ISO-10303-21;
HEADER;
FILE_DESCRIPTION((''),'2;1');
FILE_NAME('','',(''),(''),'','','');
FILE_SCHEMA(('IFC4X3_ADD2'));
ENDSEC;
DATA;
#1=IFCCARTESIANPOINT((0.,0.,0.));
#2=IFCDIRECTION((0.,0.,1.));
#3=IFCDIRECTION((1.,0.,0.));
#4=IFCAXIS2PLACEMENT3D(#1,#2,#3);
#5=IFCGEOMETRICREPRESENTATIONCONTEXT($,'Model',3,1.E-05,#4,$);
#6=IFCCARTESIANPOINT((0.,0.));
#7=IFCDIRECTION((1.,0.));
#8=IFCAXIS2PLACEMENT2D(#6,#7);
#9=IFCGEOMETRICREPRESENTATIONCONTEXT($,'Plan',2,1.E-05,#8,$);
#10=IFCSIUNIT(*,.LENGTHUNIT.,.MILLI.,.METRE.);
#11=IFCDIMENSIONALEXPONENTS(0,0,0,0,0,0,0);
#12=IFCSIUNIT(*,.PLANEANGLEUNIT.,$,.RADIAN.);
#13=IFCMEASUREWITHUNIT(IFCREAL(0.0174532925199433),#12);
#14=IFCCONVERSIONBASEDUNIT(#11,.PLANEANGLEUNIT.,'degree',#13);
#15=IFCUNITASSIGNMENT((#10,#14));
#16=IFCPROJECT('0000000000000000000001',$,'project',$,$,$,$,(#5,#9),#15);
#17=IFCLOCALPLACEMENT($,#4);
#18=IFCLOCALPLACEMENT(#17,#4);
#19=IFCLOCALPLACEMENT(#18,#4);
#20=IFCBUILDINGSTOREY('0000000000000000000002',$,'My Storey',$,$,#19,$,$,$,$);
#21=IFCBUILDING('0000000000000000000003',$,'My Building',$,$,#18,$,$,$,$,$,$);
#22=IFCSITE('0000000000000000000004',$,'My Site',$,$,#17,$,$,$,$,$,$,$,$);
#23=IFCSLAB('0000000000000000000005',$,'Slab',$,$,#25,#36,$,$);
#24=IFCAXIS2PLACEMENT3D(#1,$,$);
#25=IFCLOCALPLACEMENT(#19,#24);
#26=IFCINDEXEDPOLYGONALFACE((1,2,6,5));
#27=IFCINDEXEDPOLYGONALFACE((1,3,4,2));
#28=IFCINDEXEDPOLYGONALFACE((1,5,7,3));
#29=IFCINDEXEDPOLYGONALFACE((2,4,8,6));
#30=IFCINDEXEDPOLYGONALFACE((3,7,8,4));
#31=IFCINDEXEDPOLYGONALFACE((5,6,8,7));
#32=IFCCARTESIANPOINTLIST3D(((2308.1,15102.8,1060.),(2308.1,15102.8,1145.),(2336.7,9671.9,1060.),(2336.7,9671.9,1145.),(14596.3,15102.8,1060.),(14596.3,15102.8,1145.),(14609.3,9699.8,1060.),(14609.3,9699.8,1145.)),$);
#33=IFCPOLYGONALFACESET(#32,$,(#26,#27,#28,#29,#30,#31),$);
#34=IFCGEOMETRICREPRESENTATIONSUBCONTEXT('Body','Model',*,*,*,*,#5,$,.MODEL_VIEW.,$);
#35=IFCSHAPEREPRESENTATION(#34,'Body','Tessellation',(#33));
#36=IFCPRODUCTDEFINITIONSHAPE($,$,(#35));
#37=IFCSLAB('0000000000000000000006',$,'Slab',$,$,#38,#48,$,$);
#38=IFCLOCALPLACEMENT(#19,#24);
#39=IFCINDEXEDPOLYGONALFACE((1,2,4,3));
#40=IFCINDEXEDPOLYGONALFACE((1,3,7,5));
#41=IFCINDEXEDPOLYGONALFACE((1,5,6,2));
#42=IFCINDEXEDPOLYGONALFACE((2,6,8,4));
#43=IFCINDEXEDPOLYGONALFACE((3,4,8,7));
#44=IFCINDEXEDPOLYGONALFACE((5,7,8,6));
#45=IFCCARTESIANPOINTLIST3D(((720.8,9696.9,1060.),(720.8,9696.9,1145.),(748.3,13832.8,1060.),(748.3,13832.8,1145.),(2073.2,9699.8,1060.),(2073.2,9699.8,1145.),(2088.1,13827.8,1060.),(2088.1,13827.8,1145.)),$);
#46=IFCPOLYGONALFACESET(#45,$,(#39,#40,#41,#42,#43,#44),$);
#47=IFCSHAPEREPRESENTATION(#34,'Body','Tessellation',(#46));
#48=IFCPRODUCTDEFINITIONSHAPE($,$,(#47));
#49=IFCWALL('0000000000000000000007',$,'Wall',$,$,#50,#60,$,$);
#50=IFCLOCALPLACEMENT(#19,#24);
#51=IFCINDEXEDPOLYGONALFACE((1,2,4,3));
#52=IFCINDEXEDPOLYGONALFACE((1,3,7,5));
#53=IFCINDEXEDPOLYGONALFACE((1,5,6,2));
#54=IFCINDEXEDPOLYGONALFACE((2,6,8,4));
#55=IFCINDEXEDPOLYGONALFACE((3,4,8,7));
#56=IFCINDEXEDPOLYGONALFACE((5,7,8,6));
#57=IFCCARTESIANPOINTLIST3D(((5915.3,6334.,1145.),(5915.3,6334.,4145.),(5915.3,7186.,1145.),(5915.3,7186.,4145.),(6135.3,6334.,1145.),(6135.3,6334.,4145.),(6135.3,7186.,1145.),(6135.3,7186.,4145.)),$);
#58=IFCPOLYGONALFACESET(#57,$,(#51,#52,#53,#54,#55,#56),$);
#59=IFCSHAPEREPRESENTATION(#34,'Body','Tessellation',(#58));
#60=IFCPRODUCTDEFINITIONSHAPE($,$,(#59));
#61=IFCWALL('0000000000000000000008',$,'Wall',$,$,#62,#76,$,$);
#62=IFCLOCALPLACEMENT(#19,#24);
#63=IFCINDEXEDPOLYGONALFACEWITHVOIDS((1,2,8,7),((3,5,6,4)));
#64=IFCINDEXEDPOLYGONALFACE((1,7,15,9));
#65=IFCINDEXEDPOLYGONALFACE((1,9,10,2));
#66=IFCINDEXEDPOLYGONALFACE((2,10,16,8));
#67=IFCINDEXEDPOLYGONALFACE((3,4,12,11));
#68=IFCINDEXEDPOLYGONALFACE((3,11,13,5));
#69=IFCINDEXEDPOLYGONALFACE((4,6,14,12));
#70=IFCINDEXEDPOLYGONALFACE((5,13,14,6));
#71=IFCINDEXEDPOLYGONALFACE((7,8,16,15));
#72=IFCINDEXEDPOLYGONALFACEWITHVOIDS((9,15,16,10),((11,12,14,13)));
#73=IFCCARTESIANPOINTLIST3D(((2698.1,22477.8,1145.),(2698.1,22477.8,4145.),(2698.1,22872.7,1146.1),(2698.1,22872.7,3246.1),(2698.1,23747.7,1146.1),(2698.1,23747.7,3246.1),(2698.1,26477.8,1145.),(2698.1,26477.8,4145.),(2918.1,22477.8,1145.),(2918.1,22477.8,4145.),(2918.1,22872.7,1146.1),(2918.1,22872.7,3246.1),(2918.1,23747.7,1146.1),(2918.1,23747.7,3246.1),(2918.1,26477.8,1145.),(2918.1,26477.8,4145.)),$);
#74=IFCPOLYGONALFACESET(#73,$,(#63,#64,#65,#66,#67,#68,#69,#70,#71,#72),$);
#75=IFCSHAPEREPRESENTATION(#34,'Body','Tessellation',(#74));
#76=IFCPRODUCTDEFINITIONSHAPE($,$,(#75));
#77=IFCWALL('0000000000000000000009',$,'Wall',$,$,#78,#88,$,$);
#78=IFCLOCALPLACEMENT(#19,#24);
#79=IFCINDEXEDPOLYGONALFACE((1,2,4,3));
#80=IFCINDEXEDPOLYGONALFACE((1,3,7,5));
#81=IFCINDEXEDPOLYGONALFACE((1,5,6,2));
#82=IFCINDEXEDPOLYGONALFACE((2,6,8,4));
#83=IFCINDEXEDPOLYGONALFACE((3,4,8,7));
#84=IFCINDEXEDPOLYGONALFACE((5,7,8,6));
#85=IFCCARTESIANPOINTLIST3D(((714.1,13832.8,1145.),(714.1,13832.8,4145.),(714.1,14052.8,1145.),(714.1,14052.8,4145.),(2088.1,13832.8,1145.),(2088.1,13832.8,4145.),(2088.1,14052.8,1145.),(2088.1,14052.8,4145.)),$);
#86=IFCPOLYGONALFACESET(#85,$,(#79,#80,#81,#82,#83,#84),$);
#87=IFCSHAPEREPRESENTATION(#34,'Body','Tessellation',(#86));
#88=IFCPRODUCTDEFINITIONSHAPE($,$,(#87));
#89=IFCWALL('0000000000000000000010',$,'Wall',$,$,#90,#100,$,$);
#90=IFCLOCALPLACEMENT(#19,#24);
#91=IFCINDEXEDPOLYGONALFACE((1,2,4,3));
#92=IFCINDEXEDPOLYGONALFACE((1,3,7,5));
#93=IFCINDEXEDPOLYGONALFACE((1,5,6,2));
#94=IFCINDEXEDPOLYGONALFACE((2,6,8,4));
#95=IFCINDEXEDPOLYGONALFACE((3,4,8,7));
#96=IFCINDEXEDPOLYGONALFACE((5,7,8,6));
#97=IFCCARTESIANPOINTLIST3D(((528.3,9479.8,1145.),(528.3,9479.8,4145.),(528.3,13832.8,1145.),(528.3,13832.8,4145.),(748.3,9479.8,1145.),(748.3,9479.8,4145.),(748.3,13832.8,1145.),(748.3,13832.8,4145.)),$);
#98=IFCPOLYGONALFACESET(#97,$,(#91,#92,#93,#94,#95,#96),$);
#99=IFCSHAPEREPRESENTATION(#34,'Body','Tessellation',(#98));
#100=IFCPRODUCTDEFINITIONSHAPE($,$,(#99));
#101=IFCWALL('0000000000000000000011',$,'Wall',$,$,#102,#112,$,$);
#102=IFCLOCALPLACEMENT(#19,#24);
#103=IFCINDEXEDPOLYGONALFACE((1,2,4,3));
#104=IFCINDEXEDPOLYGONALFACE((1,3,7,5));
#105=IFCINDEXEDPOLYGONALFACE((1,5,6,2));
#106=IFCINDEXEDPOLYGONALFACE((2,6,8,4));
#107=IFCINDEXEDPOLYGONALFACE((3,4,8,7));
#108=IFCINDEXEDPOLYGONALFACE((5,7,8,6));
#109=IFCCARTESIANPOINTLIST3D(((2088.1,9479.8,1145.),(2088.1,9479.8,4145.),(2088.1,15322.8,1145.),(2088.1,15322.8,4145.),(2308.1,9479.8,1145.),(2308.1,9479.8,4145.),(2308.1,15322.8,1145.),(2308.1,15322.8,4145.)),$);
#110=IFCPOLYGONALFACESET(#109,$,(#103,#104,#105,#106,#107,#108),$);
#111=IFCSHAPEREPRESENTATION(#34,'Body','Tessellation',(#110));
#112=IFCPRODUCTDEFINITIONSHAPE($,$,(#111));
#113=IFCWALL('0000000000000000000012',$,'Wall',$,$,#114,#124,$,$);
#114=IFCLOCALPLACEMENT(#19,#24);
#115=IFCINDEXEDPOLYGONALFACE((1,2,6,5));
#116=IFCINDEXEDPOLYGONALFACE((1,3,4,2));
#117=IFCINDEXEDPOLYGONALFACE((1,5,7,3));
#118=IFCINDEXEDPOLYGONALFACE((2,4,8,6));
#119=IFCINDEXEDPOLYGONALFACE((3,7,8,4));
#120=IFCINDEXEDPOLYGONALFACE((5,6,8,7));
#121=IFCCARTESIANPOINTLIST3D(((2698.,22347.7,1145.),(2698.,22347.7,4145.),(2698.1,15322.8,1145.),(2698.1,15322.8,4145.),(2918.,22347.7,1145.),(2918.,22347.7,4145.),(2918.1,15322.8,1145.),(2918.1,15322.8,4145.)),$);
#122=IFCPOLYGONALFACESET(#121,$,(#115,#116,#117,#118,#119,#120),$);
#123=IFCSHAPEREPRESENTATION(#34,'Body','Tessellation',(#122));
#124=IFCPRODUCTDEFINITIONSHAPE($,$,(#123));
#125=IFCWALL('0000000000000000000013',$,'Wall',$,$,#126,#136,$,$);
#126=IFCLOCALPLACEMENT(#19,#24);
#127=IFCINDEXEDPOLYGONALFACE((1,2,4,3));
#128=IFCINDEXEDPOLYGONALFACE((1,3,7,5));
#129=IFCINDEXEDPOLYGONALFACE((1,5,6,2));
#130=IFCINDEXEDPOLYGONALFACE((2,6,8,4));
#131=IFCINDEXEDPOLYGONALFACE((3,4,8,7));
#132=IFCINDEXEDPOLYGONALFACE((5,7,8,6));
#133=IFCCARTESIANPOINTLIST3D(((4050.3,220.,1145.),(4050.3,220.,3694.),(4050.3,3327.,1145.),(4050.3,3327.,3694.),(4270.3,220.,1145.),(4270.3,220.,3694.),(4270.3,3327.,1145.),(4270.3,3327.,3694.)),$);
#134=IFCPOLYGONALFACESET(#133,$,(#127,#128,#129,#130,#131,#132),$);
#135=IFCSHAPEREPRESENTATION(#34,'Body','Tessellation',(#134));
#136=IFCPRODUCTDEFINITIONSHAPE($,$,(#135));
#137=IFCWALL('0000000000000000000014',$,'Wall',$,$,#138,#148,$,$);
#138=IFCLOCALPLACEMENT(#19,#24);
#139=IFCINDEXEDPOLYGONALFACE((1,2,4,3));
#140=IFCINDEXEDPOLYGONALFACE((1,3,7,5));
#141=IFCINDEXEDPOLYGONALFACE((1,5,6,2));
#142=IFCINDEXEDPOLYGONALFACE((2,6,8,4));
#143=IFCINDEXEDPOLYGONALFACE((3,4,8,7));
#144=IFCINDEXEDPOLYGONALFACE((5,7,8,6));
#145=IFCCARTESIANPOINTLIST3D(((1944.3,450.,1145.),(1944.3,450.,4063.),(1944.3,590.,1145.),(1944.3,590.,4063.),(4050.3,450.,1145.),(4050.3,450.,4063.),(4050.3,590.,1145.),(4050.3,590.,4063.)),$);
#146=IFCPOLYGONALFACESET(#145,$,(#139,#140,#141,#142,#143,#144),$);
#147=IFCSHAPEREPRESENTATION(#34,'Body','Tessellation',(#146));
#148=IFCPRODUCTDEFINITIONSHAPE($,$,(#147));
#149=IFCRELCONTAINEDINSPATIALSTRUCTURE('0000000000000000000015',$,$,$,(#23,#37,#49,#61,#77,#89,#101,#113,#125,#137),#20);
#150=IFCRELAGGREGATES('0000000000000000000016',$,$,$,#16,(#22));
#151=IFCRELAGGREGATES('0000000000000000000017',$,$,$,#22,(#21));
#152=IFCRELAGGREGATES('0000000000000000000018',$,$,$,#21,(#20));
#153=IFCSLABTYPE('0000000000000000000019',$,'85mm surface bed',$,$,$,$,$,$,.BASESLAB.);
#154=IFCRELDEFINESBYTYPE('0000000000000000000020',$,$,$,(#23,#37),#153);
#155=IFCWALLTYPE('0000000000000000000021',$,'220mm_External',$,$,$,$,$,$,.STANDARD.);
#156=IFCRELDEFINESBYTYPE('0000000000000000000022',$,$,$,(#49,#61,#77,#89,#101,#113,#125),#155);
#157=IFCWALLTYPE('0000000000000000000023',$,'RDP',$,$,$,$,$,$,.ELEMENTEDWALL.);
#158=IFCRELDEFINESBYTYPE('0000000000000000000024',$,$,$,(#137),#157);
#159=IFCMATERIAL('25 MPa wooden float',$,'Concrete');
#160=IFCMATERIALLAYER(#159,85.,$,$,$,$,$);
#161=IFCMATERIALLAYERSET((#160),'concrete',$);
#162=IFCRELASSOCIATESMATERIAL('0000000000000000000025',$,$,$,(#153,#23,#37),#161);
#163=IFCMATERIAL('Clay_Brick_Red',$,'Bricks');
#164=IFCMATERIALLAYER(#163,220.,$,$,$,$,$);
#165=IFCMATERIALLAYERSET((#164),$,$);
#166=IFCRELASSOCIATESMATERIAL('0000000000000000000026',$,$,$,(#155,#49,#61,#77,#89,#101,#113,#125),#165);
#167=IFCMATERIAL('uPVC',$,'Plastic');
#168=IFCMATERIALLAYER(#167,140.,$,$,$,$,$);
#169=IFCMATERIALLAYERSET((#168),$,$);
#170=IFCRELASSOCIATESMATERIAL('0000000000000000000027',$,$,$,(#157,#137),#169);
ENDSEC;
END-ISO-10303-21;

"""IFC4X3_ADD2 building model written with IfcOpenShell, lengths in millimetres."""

from ifc_helpers import new_model, entity, si_unit, converted_unit, frame, origin_with_axes, origin_2d_with_axis, place, context, subcontext, project, spatial, line, indexed_curve, outline, extrude, material, layer, layer_set, layer_usage, type_object, element, save


model = new_model("IFC4X3_ADD2")

# Units and contexts
model_context = context("Model", 3, precision=1e-05, world=origin_with_axes())
plan_context = context("Plan", 2, precision=1e-05, world=origin_2d_with_axis())
body_context_1 = subcontext(model_context, "Body", "Model", "MODEL_VIEW")
ifc_project = project(units=[si_unit("LENGTHUNIT", "METRE", prefix="MILLI"), converted_unit("PLANEANGLEUNIT", "degree", entity("IfcReal", 0.0174532925199433), si_unit("PLANEANGLEUNIT", "RADIAN"), dimensions=[0, 0, 0, 0, 0, 0, 0])], contexts=[model_context, plan_context])

# Site, building, storey
site_placement = place(None, origin_with_axes())
site = spatial("IfcSite", under=ifc_project, at=site_placement, Name="My Site")
building_placement = place(site_placement, origin_with_axes())
building = spatial("IfcBuilding", under=site, at=building_placement, Name="My Building")
storey_placement = place(building_placement, origin_with_axes())
storey = spatial("IfcBuildingStorey", under=building, at=storey_placement, Name="My Storey")

# Slabs
ifc_material_1 = material(Name="25 MPa wooden float", Category="Concrete")
ifc_layer_1 = layer(ifc_material_1, 85.0)
ifc_layer_set_1 = layer_set([ifc_layer_1], Name="concrete")
ifc_layer_usage_1 = layer_usage(ifc_layer_set_1, "AXIS3", "POSITIVE", -85.0)
slab_type = type_object("IfcSlabType", Name="85mm surface bed", PredefinedType="BASESLAB", material=ifc_layer_set_1)
slab_1_placement = place(storey_placement, frame((2336.7, 9671.9, 1145.0), z_axis=(0.0, 0.0, 1.0), x_axis=(1.0, 0.0, 0.0)))
element("IfcSlab", 1, at=slab_1_placement, inside=storey, type_object=slab_type, material=ifc_layer_usage_1, Name="Slab", context=body_context_1, shape_type="SweptSolid", body=[
    extrude(outline(indexed_curve([(12272.6, 27.9), (12259.6, 5430.9), (-28.6, 5430.8), (0.0, 0.0), (12272.6, 27.9)])), frame((0.0, 0.0, -85.0), z_axis=(0.0, 0.0, 1.0), x_axis=(1.0, 0.0, 0.0)), (0.0, 0.0, 1.0), 85.0),
])
ifc_layer_usage_2 = layer_usage(ifc_layer_set_1, "AXIS3", "POSITIVE", -85.0)
slab_2_placement = place(storey_placement, frame((748.3, 13832.8, 1145.0), z_axis=(0.0, 0.0, 1.0), x_axis=(1.0, 0.0, 0.0)))
element("IfcSlab", 2, at=slab_2_placement, inside=storey, type_object=slab_type, material=ifc_layer_usage_2, Name="Slab", context=body_context_1, shape_type="SweptSolid", body=[
    extrude(outline(indexed_curve([(-27.5, -4135.9), (1324.9, -4133.0), (1339.8, -5.0), (0.0, 0.0), (-27.5, -4135.9)])), frame((0.0, 0.0, -85.0), z_axis=(0.0, 0.0, 1.0), x_axis=(1.0, 0.0, 0.0)), (0.0, 0.0, 1.0), 85.0),
])

# Shared definitions
ifc_material_2 = material(Name="Clay_Brick_Red", Category="Bricks")
ifc_layer_2 = layer(ifc_material_2, 220.0)
ifc_layer_set_2 = layer_set([ifc_layer_2])
wall_type_1 = type_object("IfcWallType", Name="220mm_External", PredefinedType="STANDARD", material=ifc_layer_set_2)

# Wall
ifc_layer_usage_3 = layer_usage(ifc_layer_set_2, "AXIS2", "POSITIVE", 0.0)
wall_1_placement = place(storey_placement, frame((5915.3, 7186.0, 1145.0), z_axis=(0.0, 0.0, 1.0), x_axis=(0.000002, -1.0, 0.0)))
element("IfcWall", 3, at=wall_1_placement, inside=storey, type_object=wall_type_1, material=ifc_layer_usage_3, Name="Wall", context=body_context_1, shape_type="SweptSolid", body=[
    extrude(outline(indexed_curve([(0.0, 0.0), (0.0, 220.0), (852.0, 220.0), (852.0, 0.0)], segments=[line(1, 2, 3, 4, 1)])), origin_with_axes(), (0.0, 0.0, 1.0), 3000.0),
])

# Wall, opening
ifc_layer_usage_4 = layer_usage(ifc_layer_set_2, "AXIS2", "POSITIVE", 0.0)
wall_2_placement = place(storey_placement, frame((2918.1, 22477.8, 1145.0), z_axis=(0.0, 0.0, 1.0), x_axis=(-0.000004, 1.0, 0.0)))
wall_2 = element("IfcWall", 4, at=wall_2_placement, inside=storey, type_object=wall_type_1, material=ifc_layer_usage_4, Name="Wall", context=body_context_1, shape_type="SweptSolid", body=[
    extrude(outline(indexed_curve([(0.0, 0.0), (0.0, 220.0), (4000.0, 220.0), (4000.0, 0.0)], segments=[line(1, 2, 3, 4, 1)])), origin_with_axes(), (0.0, 0.0, 1.0), 3000.0),
])
opening_1_placement = place(wall_2_placement, frame((395.0, 376.8, 1.1), z_axis=(0.0, 0.0, 1.0), x_axis=(-0.000004, -1.0, 0.0)))
element("IfcOpeningElement", 5, at=opening_1_placement, cuts=wall_2, PredefinedType="OPENING", context=body_context_1, shape_type="SweptSolid", body=[
    extrude(outline(indexed_curve([(0.0, 875.0), (500.0, 875.0), (500.0, 0.0), (0.0, 0.0), (0.0, 875.0)])), origin_with_axes(), (0.0, 0.0, 1.0), 2100.0),
])

# Walls
ifc_layer_usage_5 = layer_usage(ifc_layer_set_2, "AXIS2", "POSITIVE", 0.0)
wall_3_placement = place(storey_placement, frame((714.1, 13832.8, 1145.0), z_axis=(0.0, 0.0, 1.0), x_axis=(1.0, 0.000004, 0.0)))
element("IfcWall", 6, at=wall_3_placement, inside=storey, type_object=wall_type_1, material=ifc_layer_usage_5, Name="Wall", context=body_context_1, shape_type="SweptSolid", body=[
    extrude(outline(indexed_curve([(0.0, 0.0), (0.0, 220.0), (1374.0, 220.0), (1374.0, 0.0)], segments=[line(1, 2, 3, 4, 1)])), origin_with_axes(), (0.0, 0.0, 1.0), 3000.0),
])
ifc_layer_usage_6 = layer_usage(ifc_layer_set_2, "AXIS2", "POSITIVE", 0.0)
wall_4_placement = place(storey_placement, frame((528.3, 13832.8, 1145.0), z_axis=(0.0, 0.0, 1.0), x_axis=(0.000001, -1.0, 0.0)))
element("IfcWall", 7, at=wall_4_placement, inside=storey, type_object=wall_type_1, material=ifc_layer_usage_6, Name="Wall", context=body_context_1, shape_type="SweptSolid", body=[
    extrude(outline(indexed_curve([(0.0, 0.0), (0.0, 220.0), (4353.0, 220.0), (4353.0, 0.0)], segments=[line(1, 2, 3, 4, 1)])), origin_with_axes(), (0.0, 0.0, 1.0), 3000.0),
])
ifc_layer_usage_7 = layer_usage(ifc_layer_set_2, "AXIS2", "POSITIVE", 0.0)
wall_5_placement = place(storey_placement, frame((2088.1, 15322.8, 1145.0), z_axis=(0.0, 0.0, 1.0), x_axis=(0.000001, -1.0, 0.0)))
element("IfcWall", 8, at=wall_5_placement, inside=storey, type_object=wall_type_1, material=ifc_layer_usage_7, Name="Wall", context=body_context_1, shape_type="SweptSolid", body=[
    extrude(outline(indexed_curve([(0.0, 0.0), (0.0, 220.0), (5843.0, 220.0), (5843.0, 0.0)], segments=[line(1, 2, 3, 4, 1)])), origin_with_axes(), (0.0, 0.0, 1.0), 3000.0),
])
ifc_layer_usage_8 = layer_usage(ifc_layer_set_2, "AXIS2", "POSITIVE", 0.0)
wall_6_placement = place(storey_placement, frame((2918.1, 15322.8, 1145.0), z_axis=(0.0, 0.0, 1.0), x_axis=(-0.000004, 1.0, 0.0)))
element("IfcWall", 9, at=wall_6_placement, inside=storey, type_object=wall_type_1, material=ifc_layer_usage_8, Name="Wall", context=body_context_1, shape_type="SweptSolid", body=[
    extrude(outline(indexed_curve([(0.0, 0.0), (0.0, 220.0), (7024.9, 220.0), (7024.9, 0.0)], segments=[line(1, 2, 3, 4, 1)])), origin_with_axes(), (0.0, 0.0, 1.0), 3000.0),
])
ifc_layer_usage_9 = layer_usage(ifc_layer_set_2, "AXIS2", "NEGATIVE", 0.0)
wall_7_placement = place(storey_placement, frame((4270.3, 3327.0, 1145.0), z_axis=(0.0, 0.0, 1.0), x_axis=(0.0, -1.0, 0.0)))
element("IfcWall", 10, at=wall_7_placement, inside=storey, type_object=wall_type_1, material=ifc_layer_usage_9, Name="Wall", context=body_context_1, shape_type="SweptSolid", body=[
    extrude(outline(indexed_curve([(0.0, -220.0), (0.0, 0.0), (3107.0, 0.0), (3107.0, -220.0)], segments=[line(1, 2, 3, 4, 1)])), origin_with_axes(), (0.0, 0.0, 1.0), 2549.0),
])
ifc_material_3 = material(Name="uPVC", Category="Plastic")
ifc_layer_3 = layer(ifc_material_3, 140.0)
ifc_layer_set_3 = layer_set([ifc_layer_3])
ifc_layer_usage_10 = layer_usage(ifc_layer_set_3, "AXIS2", "POSITIVE", 0.0)
wall_type_2 = type_object("IfcWallType", Name="RDP", PredefinedType="ELEMENTEDWALL", material=ifc_layer_set_3)
wall_8_placement = place(storey_placement, frame((4050.3, 590.0, 1145.0), z_axis=(0.0, 0.0, 1.0), x_axis=(-1.0, 0.0, 0.0)))
element("IfcWall", 11, at=wall_8_placement, inside=storey, type_object=wall_type_2, material=ifc_layer_usage_10, Name="Wall", context=body_context_1, shape_type="SweptSolid", body=[
    extrude(outline(indexed_curve([(0.0, 0.0), (0.0, 140.0), (2106.0, 140.0), (2106.0, 0.0)], segments=[line(1, 2, 3, 4, 1)])), origin_with_axes(), (0.0, 0.0, 1.0), 2918.0),
])

save(model, "model.ifc")
